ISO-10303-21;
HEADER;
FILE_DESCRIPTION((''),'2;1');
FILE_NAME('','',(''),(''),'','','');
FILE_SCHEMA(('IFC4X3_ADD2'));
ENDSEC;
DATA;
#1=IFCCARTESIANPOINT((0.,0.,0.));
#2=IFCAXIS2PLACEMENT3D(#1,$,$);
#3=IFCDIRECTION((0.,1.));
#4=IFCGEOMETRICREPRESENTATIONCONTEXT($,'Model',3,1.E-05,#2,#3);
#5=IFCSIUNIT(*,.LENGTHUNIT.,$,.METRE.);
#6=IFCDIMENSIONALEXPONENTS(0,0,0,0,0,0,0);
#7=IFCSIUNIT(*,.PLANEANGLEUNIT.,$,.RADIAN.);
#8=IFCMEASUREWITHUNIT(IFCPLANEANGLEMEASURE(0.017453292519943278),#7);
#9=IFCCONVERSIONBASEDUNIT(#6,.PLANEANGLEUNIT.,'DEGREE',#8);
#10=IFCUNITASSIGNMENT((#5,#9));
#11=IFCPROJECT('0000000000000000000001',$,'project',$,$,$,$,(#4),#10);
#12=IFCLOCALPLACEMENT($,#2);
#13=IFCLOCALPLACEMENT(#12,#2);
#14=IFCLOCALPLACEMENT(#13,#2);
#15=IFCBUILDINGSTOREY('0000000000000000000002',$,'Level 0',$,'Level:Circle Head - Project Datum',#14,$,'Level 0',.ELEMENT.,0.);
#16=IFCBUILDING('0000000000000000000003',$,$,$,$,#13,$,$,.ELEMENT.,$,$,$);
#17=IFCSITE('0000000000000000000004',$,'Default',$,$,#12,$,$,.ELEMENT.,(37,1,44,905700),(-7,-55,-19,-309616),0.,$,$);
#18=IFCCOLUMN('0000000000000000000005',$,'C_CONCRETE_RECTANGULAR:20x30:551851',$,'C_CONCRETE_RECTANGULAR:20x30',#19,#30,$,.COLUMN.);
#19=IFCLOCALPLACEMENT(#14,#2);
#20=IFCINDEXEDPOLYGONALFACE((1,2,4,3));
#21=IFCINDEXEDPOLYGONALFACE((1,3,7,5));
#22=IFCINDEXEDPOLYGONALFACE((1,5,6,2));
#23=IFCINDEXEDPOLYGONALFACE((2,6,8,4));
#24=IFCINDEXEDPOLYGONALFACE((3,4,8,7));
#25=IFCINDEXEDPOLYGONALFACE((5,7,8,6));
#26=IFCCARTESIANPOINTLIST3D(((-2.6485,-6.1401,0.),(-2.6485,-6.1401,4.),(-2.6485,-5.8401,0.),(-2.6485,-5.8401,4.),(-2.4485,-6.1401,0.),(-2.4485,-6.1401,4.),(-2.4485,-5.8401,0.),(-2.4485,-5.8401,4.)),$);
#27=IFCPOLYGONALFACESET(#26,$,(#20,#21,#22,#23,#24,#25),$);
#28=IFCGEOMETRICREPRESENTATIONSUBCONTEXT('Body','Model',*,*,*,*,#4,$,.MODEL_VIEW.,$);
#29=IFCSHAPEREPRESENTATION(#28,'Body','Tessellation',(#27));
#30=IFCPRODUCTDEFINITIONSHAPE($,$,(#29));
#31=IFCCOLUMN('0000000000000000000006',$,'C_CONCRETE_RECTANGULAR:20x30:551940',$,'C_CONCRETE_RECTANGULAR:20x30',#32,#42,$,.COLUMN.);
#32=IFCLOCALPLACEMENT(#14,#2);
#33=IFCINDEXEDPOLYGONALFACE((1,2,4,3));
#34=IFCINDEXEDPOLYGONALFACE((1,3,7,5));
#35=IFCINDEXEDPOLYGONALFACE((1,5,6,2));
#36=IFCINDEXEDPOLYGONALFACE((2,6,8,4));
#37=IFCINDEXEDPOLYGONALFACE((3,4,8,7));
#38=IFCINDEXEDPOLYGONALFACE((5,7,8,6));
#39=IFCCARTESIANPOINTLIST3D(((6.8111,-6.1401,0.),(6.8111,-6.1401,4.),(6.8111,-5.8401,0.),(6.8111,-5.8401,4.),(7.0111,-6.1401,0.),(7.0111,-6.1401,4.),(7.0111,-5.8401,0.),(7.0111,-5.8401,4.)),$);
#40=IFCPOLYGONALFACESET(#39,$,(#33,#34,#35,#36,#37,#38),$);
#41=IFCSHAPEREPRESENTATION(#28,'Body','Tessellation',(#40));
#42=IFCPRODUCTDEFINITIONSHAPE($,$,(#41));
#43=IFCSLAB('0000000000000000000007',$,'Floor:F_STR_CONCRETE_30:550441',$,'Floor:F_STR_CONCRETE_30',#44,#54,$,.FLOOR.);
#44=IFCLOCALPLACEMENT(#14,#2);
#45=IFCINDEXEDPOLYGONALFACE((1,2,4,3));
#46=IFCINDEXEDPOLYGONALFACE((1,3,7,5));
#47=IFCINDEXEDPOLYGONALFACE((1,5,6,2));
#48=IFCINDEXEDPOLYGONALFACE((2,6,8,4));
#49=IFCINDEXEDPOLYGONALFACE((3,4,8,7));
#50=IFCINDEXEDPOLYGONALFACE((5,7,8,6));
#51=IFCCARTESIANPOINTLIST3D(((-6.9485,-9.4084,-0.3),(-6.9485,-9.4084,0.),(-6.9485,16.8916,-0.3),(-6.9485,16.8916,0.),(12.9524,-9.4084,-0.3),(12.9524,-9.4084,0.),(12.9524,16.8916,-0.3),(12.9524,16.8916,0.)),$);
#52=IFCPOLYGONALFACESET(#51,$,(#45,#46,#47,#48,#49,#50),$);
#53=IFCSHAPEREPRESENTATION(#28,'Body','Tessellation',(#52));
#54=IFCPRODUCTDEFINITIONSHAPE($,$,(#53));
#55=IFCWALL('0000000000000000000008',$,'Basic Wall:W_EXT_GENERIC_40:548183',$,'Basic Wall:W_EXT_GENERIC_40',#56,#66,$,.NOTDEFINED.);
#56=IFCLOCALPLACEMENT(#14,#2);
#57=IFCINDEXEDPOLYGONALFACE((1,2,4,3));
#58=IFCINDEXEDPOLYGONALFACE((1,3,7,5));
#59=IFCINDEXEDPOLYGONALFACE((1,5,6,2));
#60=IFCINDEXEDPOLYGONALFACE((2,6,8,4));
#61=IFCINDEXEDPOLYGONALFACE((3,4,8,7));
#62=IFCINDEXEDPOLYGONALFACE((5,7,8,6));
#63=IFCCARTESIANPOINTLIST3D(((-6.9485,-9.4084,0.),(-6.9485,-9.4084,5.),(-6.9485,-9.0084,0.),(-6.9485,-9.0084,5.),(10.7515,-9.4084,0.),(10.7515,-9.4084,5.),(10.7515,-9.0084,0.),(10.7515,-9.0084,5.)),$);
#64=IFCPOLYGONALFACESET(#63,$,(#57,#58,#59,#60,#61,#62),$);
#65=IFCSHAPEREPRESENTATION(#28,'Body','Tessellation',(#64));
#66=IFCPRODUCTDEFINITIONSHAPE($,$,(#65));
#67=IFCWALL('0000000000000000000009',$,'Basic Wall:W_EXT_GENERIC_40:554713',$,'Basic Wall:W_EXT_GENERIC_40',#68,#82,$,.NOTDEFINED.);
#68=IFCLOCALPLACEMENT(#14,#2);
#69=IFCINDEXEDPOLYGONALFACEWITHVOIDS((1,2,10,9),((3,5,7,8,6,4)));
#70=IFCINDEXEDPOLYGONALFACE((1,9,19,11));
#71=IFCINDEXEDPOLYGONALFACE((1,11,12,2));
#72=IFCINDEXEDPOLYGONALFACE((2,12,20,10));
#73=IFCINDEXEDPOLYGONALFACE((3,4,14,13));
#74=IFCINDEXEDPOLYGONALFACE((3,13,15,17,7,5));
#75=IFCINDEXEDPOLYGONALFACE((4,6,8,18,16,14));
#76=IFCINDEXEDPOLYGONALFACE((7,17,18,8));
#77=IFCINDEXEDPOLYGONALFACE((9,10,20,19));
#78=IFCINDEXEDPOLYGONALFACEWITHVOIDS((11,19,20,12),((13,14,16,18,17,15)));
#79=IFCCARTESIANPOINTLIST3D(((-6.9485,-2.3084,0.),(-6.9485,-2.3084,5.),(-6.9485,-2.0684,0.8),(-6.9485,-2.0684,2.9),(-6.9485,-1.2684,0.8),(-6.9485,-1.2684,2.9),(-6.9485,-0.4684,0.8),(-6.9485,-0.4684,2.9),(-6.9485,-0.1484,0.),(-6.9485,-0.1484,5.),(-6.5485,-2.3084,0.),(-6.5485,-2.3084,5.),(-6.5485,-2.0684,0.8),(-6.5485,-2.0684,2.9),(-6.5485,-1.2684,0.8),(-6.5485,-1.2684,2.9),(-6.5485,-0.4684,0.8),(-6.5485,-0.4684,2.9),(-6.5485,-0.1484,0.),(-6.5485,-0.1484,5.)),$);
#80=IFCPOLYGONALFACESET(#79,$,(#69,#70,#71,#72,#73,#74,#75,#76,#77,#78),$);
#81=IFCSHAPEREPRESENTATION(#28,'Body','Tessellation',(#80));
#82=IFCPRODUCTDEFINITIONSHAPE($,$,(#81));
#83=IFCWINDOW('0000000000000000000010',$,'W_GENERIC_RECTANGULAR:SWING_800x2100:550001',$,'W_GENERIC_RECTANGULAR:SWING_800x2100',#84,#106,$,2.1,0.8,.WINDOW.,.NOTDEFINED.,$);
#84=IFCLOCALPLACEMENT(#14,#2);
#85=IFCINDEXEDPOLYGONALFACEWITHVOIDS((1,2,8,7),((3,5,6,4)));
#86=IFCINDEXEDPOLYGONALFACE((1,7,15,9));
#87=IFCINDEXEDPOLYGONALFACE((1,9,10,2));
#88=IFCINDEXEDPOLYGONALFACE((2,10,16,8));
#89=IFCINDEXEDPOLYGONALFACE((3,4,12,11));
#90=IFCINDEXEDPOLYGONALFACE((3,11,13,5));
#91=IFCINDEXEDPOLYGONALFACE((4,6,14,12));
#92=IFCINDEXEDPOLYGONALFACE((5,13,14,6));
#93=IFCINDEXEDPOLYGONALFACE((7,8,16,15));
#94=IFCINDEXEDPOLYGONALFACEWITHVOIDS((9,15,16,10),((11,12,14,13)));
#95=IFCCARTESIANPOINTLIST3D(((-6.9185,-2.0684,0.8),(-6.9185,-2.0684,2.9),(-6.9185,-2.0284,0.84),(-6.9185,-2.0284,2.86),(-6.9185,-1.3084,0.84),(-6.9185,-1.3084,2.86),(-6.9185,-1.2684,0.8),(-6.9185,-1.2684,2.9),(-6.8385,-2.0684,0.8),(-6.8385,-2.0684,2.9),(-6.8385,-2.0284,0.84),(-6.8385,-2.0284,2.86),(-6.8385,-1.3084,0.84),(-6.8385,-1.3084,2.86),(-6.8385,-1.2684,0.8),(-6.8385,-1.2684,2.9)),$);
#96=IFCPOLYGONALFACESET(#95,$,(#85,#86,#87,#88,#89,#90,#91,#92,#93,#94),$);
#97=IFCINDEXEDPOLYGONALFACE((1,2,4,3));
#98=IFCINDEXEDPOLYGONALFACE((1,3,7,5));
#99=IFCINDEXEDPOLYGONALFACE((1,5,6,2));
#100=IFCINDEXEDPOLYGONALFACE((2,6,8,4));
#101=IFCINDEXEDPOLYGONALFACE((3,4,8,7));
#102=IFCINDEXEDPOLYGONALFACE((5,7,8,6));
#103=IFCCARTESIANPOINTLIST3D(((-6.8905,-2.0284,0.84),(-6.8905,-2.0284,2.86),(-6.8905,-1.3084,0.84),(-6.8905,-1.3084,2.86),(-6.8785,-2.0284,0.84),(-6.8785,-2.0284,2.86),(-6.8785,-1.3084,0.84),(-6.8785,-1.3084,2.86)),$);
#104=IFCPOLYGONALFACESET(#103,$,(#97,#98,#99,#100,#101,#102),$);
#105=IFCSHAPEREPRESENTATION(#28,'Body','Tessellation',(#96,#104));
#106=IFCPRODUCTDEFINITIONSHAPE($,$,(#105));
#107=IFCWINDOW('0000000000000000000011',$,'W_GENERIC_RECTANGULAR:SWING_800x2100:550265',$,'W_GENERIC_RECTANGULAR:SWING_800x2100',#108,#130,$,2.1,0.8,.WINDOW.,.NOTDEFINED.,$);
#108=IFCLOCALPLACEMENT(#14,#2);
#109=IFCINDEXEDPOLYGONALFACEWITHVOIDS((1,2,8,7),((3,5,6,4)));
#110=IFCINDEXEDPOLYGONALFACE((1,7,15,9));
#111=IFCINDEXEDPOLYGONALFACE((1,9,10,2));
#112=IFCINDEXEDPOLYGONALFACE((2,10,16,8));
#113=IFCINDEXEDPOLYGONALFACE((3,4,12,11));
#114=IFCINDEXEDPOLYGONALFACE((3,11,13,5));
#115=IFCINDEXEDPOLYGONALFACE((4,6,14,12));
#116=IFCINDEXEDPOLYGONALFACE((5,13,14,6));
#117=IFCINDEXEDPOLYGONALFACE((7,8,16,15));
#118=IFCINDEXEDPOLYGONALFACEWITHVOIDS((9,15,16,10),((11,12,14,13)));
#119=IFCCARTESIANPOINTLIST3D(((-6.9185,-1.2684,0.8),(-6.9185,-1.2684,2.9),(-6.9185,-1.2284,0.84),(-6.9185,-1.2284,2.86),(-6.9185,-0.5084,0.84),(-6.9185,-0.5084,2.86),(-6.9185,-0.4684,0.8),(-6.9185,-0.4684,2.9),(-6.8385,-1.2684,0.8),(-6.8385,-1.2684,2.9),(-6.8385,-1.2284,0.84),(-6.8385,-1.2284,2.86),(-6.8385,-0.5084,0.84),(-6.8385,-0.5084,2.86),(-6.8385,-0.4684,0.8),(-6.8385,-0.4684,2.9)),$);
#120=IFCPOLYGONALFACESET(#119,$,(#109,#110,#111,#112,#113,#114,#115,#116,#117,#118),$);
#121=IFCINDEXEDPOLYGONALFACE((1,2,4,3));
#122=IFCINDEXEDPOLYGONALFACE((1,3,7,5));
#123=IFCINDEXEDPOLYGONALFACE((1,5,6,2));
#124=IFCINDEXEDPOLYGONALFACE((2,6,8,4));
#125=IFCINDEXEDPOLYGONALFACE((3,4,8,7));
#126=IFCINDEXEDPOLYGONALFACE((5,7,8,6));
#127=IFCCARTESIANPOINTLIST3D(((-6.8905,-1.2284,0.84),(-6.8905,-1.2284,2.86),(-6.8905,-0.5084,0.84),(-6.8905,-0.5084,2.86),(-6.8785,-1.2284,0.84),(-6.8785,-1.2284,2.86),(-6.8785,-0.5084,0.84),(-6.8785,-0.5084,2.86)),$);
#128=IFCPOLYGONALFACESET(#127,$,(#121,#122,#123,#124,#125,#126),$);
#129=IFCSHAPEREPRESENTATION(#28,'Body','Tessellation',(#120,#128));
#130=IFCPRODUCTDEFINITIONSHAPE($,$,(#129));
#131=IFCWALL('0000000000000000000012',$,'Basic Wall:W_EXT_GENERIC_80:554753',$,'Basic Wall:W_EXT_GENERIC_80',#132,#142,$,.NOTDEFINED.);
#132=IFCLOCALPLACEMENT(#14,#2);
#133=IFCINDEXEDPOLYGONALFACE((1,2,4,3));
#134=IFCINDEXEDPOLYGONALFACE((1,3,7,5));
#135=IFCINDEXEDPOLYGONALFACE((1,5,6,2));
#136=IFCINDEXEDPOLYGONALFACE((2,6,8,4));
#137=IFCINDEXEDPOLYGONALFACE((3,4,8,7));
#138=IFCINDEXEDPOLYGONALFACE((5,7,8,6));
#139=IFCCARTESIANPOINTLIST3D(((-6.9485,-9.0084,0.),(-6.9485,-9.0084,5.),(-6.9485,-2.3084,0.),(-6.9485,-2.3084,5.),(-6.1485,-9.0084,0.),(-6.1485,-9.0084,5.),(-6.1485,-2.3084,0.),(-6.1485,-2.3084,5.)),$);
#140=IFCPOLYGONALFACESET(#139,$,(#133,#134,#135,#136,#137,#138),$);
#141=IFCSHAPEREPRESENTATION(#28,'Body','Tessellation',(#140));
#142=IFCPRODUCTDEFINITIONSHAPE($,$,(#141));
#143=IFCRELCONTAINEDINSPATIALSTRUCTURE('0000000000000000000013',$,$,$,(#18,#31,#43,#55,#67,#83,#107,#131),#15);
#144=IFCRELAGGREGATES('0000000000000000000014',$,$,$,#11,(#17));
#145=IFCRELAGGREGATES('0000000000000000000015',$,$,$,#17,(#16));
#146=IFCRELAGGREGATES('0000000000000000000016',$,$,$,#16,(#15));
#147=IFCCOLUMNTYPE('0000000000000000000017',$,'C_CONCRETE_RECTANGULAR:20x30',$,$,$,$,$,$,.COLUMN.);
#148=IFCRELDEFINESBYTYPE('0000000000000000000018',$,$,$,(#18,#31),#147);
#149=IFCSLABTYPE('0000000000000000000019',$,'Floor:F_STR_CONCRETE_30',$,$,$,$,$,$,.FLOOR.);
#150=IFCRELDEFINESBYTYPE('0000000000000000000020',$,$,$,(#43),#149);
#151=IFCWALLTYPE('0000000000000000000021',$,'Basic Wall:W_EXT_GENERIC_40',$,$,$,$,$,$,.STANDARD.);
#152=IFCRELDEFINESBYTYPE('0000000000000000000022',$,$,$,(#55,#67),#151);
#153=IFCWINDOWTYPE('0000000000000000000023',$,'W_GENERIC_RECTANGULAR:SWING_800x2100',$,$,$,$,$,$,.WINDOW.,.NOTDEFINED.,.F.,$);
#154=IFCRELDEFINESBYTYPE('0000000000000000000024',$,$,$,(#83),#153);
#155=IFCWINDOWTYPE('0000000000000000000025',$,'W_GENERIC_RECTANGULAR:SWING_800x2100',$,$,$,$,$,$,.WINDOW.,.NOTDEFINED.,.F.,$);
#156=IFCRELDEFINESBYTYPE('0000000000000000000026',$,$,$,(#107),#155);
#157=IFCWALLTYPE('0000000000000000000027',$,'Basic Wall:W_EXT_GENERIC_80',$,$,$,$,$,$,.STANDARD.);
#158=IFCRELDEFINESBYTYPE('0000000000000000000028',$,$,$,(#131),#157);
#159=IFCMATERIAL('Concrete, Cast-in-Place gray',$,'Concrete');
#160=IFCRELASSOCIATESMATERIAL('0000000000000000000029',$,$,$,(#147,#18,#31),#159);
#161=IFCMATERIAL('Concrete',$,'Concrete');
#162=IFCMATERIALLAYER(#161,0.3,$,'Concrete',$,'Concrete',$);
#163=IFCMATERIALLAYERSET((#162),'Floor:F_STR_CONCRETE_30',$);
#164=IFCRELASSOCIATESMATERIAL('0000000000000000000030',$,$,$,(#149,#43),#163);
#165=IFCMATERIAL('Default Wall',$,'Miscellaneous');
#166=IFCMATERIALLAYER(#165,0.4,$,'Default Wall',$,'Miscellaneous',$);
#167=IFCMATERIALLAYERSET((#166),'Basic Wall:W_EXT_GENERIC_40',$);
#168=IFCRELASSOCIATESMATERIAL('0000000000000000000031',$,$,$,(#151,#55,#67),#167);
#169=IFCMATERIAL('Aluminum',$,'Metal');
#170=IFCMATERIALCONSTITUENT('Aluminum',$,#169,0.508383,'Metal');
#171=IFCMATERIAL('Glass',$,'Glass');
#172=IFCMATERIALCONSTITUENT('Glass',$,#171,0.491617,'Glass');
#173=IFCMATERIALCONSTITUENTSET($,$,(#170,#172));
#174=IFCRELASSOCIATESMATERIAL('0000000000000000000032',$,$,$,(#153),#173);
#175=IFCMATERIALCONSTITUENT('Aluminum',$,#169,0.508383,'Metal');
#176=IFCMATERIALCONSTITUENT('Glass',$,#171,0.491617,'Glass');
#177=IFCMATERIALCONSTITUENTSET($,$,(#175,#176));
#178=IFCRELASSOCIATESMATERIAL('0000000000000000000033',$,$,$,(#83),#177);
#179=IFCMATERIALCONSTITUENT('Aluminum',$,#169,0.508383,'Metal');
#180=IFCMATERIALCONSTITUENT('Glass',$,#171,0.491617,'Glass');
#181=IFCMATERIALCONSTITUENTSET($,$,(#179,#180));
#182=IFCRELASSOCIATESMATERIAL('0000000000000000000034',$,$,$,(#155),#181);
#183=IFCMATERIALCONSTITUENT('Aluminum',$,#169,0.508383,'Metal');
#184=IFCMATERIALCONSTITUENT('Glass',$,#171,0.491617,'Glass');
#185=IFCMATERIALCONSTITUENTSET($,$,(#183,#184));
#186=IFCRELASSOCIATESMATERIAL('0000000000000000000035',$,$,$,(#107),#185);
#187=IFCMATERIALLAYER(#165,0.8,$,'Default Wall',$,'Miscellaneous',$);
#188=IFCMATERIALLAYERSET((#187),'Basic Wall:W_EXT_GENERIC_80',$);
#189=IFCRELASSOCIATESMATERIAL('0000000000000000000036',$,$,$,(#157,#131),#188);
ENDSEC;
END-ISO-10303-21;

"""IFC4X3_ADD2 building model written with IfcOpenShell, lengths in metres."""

from ifc_helpers import new_model, entity, si_unit, converted_unit, direction, frame, frame_2d, origin, origin_2d_with_axis, place, context, subcontext, project, spatial, polyline, rectangle, outline, extrude, source, transform, mapped, material, layer, layer_set, layer_usage, constituent, constituent_set, material_profile, profile_set, profile_usage, type_object, type_shapes, element, fill, save


model = new_model("IFC4X3_ADD2")

# Units and contexts
model_context = context("Model", 3, precision=1e-05, world=origin(), true_north=direction((0.0, 1.0)))
body_context = subcontext(model_context, "Body", "Model", "MODEL_VIEW")
ifc_project = project(units=[si_unit("LENGTHUNIT", "METRE"), converted_unit("PLANEANGLEUNIT", "DEGREE", entity("IfcPlaneAngleMeasure", 0.017453292519943278), si_unit("PLANEANGLEUNIT", "RADIAN"), dimensions=[0, 0, 0, 0, 0, 0, 0])], contexts=[model_context])

# Site, building, storey
site_placement = place(None, origin())
site = spatial("IfcSite", under=ifc_project, at=site_placement, Name="Default", CompositionType="ELEMENT", RefLatitude=(37, 1, 44, 905700), RefLongitude=(-7, -55, -19, -309616), RefElevation=0.0)
building_placement = place(site_placement, origin())
building = spatial("IfcBuilding", under=site, at=building_placement, CompositionType="ELEMENT")
storey_placement = place(building_placement, origin())
storey = spatial("IfcBuildingStorey", under=building, at=storey_placement, Name="Level 0", ObjectType="Level:Circle Head - Project Datum", LongName="Level 0", CompositionType="ELEMENT", Elevation=0.0)

# Columns
ifc_material_1 = material(Name="Concrete, Cast-in-Place gray", Category="Concrete")
ifc_material_profile = material_profile(ifc_material_1, rectangle(XDim=0.2, YDim=0.3, at=origin_2d_with_axis()), Name="20x30")
ifc_profile_set = profile_set([ifc_material_profile], Name="20x30")
ifc_profile_usage = profile_usage(ifc_profile_set)
column_type = type_object("IfcColumnType", Name="C_CONCRETE_RECTANGULAR:20x30", PredefinedType="COLUMN", material=ifc_profile_set)
shared_shape_1 = source(origin(), body_context, "Body", "SweptSolid", [
    extrude(rectangle(XDim=0.2, YDim=0.3, at=origin_2d_with_axis()), frame((0.0, 0.0, 0.0), z_axis=(0.0, 0.0, 1.0), x_axis=(-1.0, 0.0, 0.0)), (0.0, 0.0, 1.0), 4.0),
])
type_shapes(column_type, [shared_shape_1])
for number, where, name in (
    (1, (-2.5485, -5.9901, 0.0), "C_CONCRETE_RECTANGULAR:20x30:551851"),
    (2, (6.9111, -5.9901, 0.0), "C_CONCRETE_RECTANGULAR:20x30:551940"),
):
    element("IfcColumn", number, at=place(storey_placement, frame(where)), inside=storey, type_object=column_type, material=ifc_profile_usage, Name=name, ObjectType="C_CONCRETE_RECTANGULAR:20x30", PredefinedType="COLUMN", context=body_context, shape_type="MappedRepresentation", body=[
        mapped(shared_shape_1, transform((0.0, 0.0, 0.0), scale=1.0)),
    ])

# Slab
ifc_material_2 = material(Name="Concrete", Category="Concrete")
ifc_layer_1 = layer(ifc_material_2, 0.3, Name="Concrete", Category="Concrete")
ifc_layer_set_1 = layer_set([ifc_layer_1], Name="Floor:F_STR_CONCRETE_30")
ifc_layer_usage_1 = layer_usage(ifc_layer_set_1, "AXIS3", "POSITIVE", 0.0)
slab_type = type_object("IfcSlabType", Name="Floor:F_STR_CONCRETE_30", PredefinedType="FLOOR", material=ifc_layer_set_1)
slab_placement = place(storey_placement, origin())
element("IfcSlab", 3, at=slab_placement, inside=storey, type_object=slab_type, material=ifc_layer_usage_1, Name="Floor:F_STR_CONCRETE_30:550441", ObjectType="Floor:F_STR_CONCRETE_30", PredefinedType="FLOOR", context=body_context, shape_type="SweptSolid", body=[
    extrude(rectangle(XDim=26.3, YDim=19.9008, at=origin_2d_with_axis()), frame((3.0019, 3.7416, 0.0), z_axis=(0.0, 0.0, -1.0), x_axis=(0.0, 1.0, 0.0)), (0.0, 0.0, 1.0), 0.3),
])

# Wall
ifc_material_3 = material(Name="Default Wall", Category="Miscellaneous")
ifc_layer_2 = layer(ifc_material_3, 0.4, Name="Default Wall", Category="Miscellaneous")
ifc_layer_set_2 = layer_set([ifc_layer_2], Name="Basic Wall:W_EXT_GENERIC_40")
wall_type_1 = type_object("IfcWallType", Name="Basic Wall:W_EXT_GENERIC_40", PredefinedType="STANDARD", material=ifc_layer_set_2)
wall_1_placement = place(storey_placement, frame((10.7515, -9.2084, 0.0), z_axis=(0.0, 0.0, 1.0), x_axis=(-1.0, 0.0, 0.0)))
element("IfcWall", 4, at=wall_1_placement, inside=storey, type_object=wall_type_1, material=ifc_layer_set_2, Name="Basic Wall:W_EXT_GENERIC_40:548183", ObjectType="Basic Wall:W_EXT_GENERIC_40", PredefinedType="NOTDEFINED", context=body_context, shape_type="SweptSolid", body=[
    extrude(rectangle(XDim=17.7, YDim=0.4, at=frame_2d((8.85, 0.0), x_axis=(-1.0, 0.0))), origin(), (0.0, 0.0, 1.0), 5.0),
])

# Wall, openings, windows
wall_2_placement = place(storey_placement, frame((-6.7485, -0.1484, 0.0), z_axis=(0.0, 0.0, 1.0), x_axis=(0.0, -1.0, 0.0)))
wall_2 = element("IfcWall", 5, at=wall_2_placement, inside=storey, type_object=wall_type_1, material=ifc_layer_set_2, Name="Basic Wall:W_EXT_GENERIC_40:554713", ObjectType="Basic Wall:W_EXT_GENERIC_40", PredefinedType="NOTDEFINED", context=body_context, shape_type="SweptSolid", body=[
    extrude(rectangle(XDim=2.16, YDim=0.4, at=frame_2d((1.08, 0.0), x_axis=(-1.0, 0.0))), origin(), (0.0, 0.0, 1.0), 5.0),
])
opening_1_placement = place(wall_2_placement, frame((1.12, -0.2, 0.8)))
opening_1 = element("IfcOpeningElement", 6, at=opening_1_placement, cuts=wall_2, PredefinedType="OPENING", context=body_context, shape_type="SweptSolid", body=[
    extrude(rectangle(XDim=2.1, YDim=0.8, at=frame_2d((1.05, 0.4), x_axis=(-1.0, 0.0))), frame((0.0, 0.0, 0.0), z_axis=(0.0, 1.0, 0.0), x_axis=(0.0, 0.0, 1.0)), (0.0, 0.0, 1.0), 0.4),
])
opening_2_placement = place(wall_2_placement, frame((-0.1484, 6.7485, 0.8), z_axis=(0.0, 0.0, 1.0), x_axis=(0.0, 1.0, 0.0)))
element("IfcOpeningElement", 7, at=opening_2_placement, cuts=wall_2, PredefinedType="OPENING", context=body_context, shape_type="SweptSolid", body=[
    extrude(rectangle(XDim=2.1, YDim=0.8, at=origin_2d_with_axis()), frame((-8.4725, -1.6684, 1.05), z_axis=(1.0, 0.0, 0.0), x_axis=(0.0, 0.0, -1.0)), (0.0, 0.0, 1.0), 3.048),
])
opening_3_placement = place(wall_2_placement, frame((0.32, -0.2, 0.8)))
opening_3 = element("IfcOpeningElement", 8, at=opening_3_placement, cuts=wall_2, PredefinedType="OPENING", context=body_context, shape_type="SweptSolid", body=[
    extrude(rectangle(XDim=2.1, YDim=0.8, at=frame_2d((1.05, 0.4), x_axis=(-1.0, 0.0))), frame((0.0, 0.0, 0.0), z_axis=(0.0, 1.0, 0.0), x_axis=(0.0, 0.0, 1.0)), (0.0, 0.0, 1.0), 0.4),
])
opening_4_placement = place(wall_2_placement, frame((-0.1484, 6.7485, 0.8), z_axis=(0.0, 0.0, 1.0), x_axis=(0.0, 1.0, 0.0)))
element("IfcOpeningElement", 9, at=opening_4_placement, cuts=wall_2, PredefinedType="OPENING", context=body_context, shape_type="SweptSolid", body=[
    extrude(rectangle(XDim=2.1, YDim=0.8, at=frame_2d((0.0, 0.0), x_axis=(0.0, 1.0))), frame((-8.4725, -0.8684, 1.05), z_axis=(1.0, 0.0, 0.0), x_axis=(0.0, -1.0, 0.0)), (0.0, 0.0, 1.0), 3.048),
])
ifc_material_4 = material(Name="Aluminum", Category="Metal")
ifc_constituent_1 = constituent(ifc_material_4, Name="Aluminum", Category="Metal", fraction=0.508383)
ifc_material_5 = material(Name="Glass", Category="Glass")
ifc_constituent_2 = constituent(ifc_material_5, Name="Glass", Category="Glass", fraction=0.491617)
ifc_constituent_set_1 = constituent_set(constituents=[ifc_constituent_1, ifc_constituent_2])
ifc_constituent_3 = constituent(ifc_material_4, Name="Aluminum", Category="Metal", fraction=0.508383)
ifc_constituent_4 = constituent(ifc_material_5, Name="Glass", Category="Glass", fraction=0.491617)
ifc_constituent_set_2 = constituent_set(constituents=[ifc_constituent_3, ifc_constituent_4])
window_type_1 = type_object("IfcWindowType", Name="W_GENERIC_RECTANGULAR:SWING_800x2100", ParameterTakesPrecedence=False, PartitioningType="NOTDEFINED", PredefinedType="WINDOW", material=ifc_constituent_set_2)
shared_shape_2 = source(origin(), body_context, "Body", "SweptSolid", [
    extrude(outline(polyline([(-0.4, -1.05), (0.4, -1.05), (0.4, 1.05), (-0.4, 1.05), (-0.4, -1.05)]), holes=[polyline([(-0.36, 1.01), (0.36, 1.01), (0.36, -1.01), (-0.36, -1.01), (-0.36, 1.01)])]), frame((0.15, 0.11, 1.05), z_axis=(0.0, -1.0, 0.0), x_axis=(1.0, 0.0, 0.0)), (0.0, 0.0, 1.0), 0.08),
    extrude(rectangle(XDim=0.012, YDim=0.72, at=frame_2d((0.0, 0.0), x_axis=(1.0, 0.0))), frame((0.15, 0.064, 0.04), z_axis=(0.0, 0.0, 1.0), x_axis=(0.0, -1.0, 0.0)), (0.0, 0.0, 1.0), 2.02),
])
type_shapes(window_type_1, [shared_shape_2])
window_1_placement = place(opening_1_placement, frame((0.25, 0.0, 0.0)))
window_1 = element("IfcWindow", 10, at=window_1_placement, inside=storey, type_object=window_type_1, material=ifc_constituent_set_1, Name="W_GENERIC_RECTANGULAR:SWING_800x2100:550001", ObjectType="W_GENERIC_RECTANGULAR:SWING_800x2100", OverallHeight=2.1, OverallWidth=0.8, PartitioningType="NOTDEFINED", PredefinedType="WINDOW", context=body_context, shape_type="MappedRepresentation", body=[
    mapped(shared_shape_2, transform((0.0, 0.0, 0.0), scale=1.0)),
])
fill(opening_1, window_1)
ifc_constituent_5 = constituent(ifc_material_4, Name="Aluminum", Category="Metal", fraction=0.508383)
ifc_constituent_6 = constituent(ifc_material_5, Name="Glass", Category="Glass", fraction=0.491617)
ifc_constituent_set_3 = constituent_set(constituents=[ifc_constituent_5, ifc_constituent_6])
ifc_constituent_7 = constituent(ifc_material_4, Name="Aluminum", Category="Metal", fraction=0.508383)
ifc_constituent_8 = constituent(ifc_material_5, Name="Glass", Category="Glass", fraction=0.491617)
ifc_constituent_set_4 = constituent_set(constituents=[ifc_constituent_7, ifc_constituent_8])
window_type_2 = type_object("IfcWindowType", Name="W_GENERIC_RECTANGULAR:SWING_800x2100", ParameterTakesPrecedence=False, PartitioningType="NOTDEFINED", PredefinedType="WINDOW", material=ifc_constituent_set_4)
shared_shape_3 = source(origin(), body_context, "Body", "SweptSolid", [
    extrude(outline(polyline([(-1.05, -0.4), (1.05, -0.4), (1.05, 0.4), (-1.05, 0.4), (-1.05, -0.4)]), holes=[polyline([(1.01, -0.36), (-1.01, -0.36), (-1.01, 0.36), (1.01, 0.36), (1.01, -0.36)])]), frame((0.4, 0.03, 1.05), z_axis=(0.0, 1.0, 0.0), x_axis=(0.0, 0.0, -1.0)), (0.0, 0.0, 1.0), 0.08),
    extrude(rectangle(XDim=0.72, YDim=0.012, at=frame_2d((0.0, 0.0), x_axis=(1.0, 0.0))), frame((0.4, 0.064, 0.04), z_axis=(0.0, 0.0, 1.0), x_axis=(-1.0, 0.0, 0.0)), (0.0, 0.0, 1.0), 2.02),
])
type_shapes(window_type_2, [shared_shape_3])
window_2_placement = place(opening_3_placement, origin())
window_2 = element("IfcWindow", 11, at=window_2_placement, inside=storey, type_object=window_type_2, material=ifc_constituent_set_3, Name="W_GENERIC_RECTANGULAR:SWING_800x2100:550265", ObjectType="W_GENERIC_RECTANGULAR:SWING_800x2100", OverallHeight=2.1, OverallWidth=0.8, PartitioningType="NOTDEFINED", PredefinedType="WINDOW", context=body_context, shape_type="MappedRepresentation", body=[
    mapped(shared_shape_3, transform((0.0, 0.0, 0.0), scale=1.0)),
])
fill(opening_3, window_2)

# Wall
ifc_layer_3 = layer(ifc_material_3, 0.8, Name="Default Wall", Category="Miscellaneous")
ifc_layer_set_3 = layer_set([ifc_layer_3], Name="Basic Wall:W_EXT_GENERIC_80")
wall_type_2 = type_object("IfcWallType", Name="Basic Wall:W_EXT_GENERIC_80", PredefinedType="STANDARD", material=ifc_layer_set_3)
wall_3_placement = place(storey_placement, frame((-6.5485, -2.3084, 0.0), z_axis=(0.0, 0.0, 1.0), x_axis=(0.0, -1.0, 0.0)))
element("IfcWall", 12, at=wall_3_placement, inside=storey, type_object=wall_type_2, material=ifc_layer_set_3, Name="Basic Wall:W_EXT_GENERIC_80:554753", ObjectType="Basic Wall:W_EXT_GENERIC_80", PredefinedType="NOTDEFINED", context=body_context, shape_type="SweptSolid", body=[
    extrude(rectangle(XDim=6.7, YDim=0.8, at=frame_2d((3.35, 0.0), x_axis=(-1.0, 0.0))), origin(), (0.0, 0.0, 1.0), 5.0),
])

save(model, "model.ifc")
